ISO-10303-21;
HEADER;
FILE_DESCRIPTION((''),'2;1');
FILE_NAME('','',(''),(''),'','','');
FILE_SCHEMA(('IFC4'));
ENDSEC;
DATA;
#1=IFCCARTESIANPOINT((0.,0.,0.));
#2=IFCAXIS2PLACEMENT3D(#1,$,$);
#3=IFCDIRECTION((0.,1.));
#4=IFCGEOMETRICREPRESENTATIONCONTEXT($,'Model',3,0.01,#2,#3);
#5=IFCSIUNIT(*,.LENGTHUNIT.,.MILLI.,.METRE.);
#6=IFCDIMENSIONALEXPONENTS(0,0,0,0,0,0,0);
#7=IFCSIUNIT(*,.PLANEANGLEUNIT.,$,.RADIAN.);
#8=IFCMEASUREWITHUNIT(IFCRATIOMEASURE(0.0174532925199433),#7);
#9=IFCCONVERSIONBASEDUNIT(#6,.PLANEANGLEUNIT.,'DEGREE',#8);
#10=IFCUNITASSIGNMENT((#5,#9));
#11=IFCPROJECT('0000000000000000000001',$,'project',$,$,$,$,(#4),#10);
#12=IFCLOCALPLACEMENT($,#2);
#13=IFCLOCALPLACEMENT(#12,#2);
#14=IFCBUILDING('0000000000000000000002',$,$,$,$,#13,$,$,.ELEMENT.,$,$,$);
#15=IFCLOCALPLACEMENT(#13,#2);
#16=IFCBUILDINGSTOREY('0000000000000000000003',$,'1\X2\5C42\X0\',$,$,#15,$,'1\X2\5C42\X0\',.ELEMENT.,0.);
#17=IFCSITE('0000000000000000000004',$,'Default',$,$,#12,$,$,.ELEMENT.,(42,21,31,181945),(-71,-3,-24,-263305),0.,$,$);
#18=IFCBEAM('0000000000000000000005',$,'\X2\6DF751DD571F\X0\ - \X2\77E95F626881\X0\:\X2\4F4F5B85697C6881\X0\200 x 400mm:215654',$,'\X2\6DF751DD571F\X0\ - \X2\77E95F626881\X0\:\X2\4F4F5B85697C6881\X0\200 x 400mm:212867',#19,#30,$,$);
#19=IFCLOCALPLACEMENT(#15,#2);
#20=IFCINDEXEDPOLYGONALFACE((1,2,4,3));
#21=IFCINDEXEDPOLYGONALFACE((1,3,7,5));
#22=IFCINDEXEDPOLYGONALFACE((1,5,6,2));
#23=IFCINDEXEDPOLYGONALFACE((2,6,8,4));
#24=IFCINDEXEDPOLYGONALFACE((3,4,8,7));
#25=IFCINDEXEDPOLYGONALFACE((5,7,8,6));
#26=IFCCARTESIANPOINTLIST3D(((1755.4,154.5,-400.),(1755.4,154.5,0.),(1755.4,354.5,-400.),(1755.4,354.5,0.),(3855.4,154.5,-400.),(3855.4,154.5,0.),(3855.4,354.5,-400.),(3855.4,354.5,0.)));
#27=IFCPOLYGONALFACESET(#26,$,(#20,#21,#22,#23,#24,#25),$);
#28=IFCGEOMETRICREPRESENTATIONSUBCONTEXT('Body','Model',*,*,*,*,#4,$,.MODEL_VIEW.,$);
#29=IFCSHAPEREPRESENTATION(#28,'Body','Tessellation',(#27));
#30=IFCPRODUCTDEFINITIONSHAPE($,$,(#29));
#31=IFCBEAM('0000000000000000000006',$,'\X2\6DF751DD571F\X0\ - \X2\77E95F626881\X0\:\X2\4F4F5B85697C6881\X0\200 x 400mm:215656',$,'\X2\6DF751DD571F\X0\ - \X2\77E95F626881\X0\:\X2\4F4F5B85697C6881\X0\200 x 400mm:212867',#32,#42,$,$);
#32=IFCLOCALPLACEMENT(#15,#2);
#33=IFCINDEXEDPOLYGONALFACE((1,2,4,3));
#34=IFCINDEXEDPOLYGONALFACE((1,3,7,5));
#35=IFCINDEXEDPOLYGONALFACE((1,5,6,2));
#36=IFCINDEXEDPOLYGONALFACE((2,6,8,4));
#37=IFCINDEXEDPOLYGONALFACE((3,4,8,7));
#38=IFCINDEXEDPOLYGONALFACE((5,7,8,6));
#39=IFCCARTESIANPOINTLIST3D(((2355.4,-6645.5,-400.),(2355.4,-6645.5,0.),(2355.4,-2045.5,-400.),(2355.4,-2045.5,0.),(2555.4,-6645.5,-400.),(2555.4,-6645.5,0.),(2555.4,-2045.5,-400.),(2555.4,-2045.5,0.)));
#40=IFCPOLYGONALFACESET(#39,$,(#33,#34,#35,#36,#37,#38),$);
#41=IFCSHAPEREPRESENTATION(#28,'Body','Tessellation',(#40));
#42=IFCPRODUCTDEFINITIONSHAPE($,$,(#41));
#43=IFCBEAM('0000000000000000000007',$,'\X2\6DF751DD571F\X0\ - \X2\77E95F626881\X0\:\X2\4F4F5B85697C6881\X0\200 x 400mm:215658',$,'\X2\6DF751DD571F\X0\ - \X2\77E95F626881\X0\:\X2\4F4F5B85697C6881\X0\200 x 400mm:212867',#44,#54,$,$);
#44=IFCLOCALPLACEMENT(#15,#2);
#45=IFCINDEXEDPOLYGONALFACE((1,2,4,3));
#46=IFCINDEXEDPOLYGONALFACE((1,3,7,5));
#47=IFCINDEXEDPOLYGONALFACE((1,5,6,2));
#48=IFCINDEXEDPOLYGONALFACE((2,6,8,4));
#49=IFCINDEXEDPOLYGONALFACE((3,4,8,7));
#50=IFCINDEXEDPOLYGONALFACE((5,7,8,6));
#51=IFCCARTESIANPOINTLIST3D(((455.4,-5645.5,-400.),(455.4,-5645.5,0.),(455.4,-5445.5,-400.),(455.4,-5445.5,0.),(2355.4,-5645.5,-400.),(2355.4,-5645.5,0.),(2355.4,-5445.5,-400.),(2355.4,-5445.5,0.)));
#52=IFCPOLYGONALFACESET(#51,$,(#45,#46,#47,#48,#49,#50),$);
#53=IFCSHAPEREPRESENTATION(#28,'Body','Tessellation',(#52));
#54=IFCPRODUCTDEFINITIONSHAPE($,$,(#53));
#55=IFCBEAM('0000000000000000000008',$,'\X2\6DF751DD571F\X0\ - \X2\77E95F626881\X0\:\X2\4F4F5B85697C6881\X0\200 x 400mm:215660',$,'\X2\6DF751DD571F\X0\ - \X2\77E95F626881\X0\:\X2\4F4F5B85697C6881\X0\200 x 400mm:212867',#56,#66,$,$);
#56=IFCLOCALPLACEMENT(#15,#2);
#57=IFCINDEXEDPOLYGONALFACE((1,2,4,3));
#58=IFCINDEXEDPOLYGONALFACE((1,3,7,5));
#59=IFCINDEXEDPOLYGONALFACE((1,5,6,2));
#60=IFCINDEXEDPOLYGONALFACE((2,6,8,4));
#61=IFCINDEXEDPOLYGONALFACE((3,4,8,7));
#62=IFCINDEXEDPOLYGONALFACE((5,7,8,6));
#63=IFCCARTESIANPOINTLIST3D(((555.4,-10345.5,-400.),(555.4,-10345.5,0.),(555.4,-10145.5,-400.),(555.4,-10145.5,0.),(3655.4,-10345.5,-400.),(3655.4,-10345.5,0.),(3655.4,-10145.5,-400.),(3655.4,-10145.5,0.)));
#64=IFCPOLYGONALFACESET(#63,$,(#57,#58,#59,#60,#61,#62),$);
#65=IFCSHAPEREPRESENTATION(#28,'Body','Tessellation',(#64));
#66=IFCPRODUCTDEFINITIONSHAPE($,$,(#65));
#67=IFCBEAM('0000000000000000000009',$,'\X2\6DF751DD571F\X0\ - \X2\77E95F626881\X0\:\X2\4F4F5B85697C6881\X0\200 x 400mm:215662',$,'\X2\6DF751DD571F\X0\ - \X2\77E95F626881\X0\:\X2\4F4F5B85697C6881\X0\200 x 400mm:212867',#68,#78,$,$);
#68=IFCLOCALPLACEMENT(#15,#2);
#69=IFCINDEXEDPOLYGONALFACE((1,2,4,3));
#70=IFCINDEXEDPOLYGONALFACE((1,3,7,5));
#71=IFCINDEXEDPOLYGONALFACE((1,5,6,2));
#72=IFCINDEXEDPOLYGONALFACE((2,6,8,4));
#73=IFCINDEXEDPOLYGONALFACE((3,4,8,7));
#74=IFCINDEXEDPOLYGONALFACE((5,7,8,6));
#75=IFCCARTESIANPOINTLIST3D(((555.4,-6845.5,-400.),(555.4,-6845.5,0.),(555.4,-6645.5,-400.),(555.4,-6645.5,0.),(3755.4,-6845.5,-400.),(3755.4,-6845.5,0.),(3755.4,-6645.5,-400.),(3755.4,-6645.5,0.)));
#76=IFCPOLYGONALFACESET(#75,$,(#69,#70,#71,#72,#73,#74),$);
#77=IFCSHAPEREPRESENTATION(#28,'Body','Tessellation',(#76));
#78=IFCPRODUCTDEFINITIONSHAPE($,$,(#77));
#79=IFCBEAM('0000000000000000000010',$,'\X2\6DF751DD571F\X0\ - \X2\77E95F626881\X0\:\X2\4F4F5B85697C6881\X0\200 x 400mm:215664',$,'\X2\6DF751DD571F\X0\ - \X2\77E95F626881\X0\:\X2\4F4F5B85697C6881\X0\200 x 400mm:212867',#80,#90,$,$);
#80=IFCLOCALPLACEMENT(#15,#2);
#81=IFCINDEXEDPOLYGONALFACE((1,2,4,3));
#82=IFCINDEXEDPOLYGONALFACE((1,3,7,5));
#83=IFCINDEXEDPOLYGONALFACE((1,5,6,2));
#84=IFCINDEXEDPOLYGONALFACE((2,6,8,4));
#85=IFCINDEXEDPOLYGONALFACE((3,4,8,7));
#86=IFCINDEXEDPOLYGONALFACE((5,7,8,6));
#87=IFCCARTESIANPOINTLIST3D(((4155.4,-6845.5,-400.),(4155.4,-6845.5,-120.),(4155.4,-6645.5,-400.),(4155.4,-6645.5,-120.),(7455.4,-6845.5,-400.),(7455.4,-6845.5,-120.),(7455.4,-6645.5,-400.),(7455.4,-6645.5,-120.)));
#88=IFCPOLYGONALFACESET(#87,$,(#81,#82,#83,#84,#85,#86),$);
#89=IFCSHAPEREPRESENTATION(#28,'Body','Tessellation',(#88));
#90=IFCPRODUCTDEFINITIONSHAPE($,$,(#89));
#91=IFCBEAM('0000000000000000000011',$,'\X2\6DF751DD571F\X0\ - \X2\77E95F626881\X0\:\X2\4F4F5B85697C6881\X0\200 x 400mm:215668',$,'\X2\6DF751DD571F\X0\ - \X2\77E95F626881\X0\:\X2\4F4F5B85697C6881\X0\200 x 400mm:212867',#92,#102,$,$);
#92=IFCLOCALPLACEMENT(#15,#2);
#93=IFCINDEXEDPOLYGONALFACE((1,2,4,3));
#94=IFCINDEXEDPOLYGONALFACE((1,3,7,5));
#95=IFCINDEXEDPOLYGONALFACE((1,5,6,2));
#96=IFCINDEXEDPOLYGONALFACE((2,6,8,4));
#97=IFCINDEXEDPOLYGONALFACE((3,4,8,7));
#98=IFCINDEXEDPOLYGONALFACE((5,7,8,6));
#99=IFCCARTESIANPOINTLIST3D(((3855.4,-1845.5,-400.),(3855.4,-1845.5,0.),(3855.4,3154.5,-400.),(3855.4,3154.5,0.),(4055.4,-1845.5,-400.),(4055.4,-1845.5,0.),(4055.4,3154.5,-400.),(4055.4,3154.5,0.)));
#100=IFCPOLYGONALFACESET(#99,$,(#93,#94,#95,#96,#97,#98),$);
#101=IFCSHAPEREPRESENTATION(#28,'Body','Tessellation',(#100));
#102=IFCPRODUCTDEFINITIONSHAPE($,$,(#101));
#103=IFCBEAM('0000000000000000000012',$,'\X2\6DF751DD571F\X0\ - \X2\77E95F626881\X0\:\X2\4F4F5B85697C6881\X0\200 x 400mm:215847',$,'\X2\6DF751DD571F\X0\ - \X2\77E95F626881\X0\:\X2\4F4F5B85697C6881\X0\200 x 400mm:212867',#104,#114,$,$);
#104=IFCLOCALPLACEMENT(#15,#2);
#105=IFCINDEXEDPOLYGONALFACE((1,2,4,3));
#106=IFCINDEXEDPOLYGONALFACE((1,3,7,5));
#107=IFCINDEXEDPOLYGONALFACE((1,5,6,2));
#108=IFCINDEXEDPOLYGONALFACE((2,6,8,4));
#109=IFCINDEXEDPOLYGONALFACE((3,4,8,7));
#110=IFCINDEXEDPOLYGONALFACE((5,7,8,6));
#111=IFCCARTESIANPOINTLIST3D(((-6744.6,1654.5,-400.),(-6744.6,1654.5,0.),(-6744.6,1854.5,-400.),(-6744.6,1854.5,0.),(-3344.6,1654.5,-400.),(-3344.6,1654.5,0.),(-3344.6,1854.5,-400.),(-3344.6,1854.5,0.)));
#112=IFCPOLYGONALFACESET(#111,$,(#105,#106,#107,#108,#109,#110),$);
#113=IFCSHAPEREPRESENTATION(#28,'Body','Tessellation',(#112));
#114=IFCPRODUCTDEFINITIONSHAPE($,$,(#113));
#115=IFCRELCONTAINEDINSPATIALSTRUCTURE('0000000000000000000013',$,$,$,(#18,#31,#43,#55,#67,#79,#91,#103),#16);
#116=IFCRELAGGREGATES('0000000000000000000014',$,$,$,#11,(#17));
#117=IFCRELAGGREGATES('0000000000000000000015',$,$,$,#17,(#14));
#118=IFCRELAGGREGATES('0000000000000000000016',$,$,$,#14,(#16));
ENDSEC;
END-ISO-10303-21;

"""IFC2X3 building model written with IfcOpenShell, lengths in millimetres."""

from ifc_helpers import new_model, entity, si_unit, converted_unit, direction, frame, frame_2d, origin, place, context, subcontext, project, spatial, rectangle, extrude, element, save


model = new_model("IFC2X3")

# Units and contexts
model_context = context("Model", 3, precision=0.01, world=origin(), true_north=direction((0.0, 1.0)))
body_context = subcontext(model_context, "Body", "Model", "MODEL_VIEW")
ifc_project = project(units=[si_unit("LENGTHUNIT", "METRE", prefix="MILLI"), converted_unit("PLANEANGLEUNIT", "DEGREE", entity("IfcRatioMeasure", 0.0174532925199433), si_unit("PLANEANGLEUNIT", "RADIAN"), dimensions=[0, 0, 0, 0, 0, 0, 0])], contexts=[model_context])

# Site, building, storey
site_placement = place(None, origin())
site = spatial("IfcSite", under=ifc_project, at=site_placement, Name="Default", CompositionType="ELEMENT", RefLatitude=(42, 21, 31, 181945), RefLongitude=(-71, -3, -24, -263305), RefElevation=0.0)
building_placement = place(site_placement, origin())
building = spatial("IfcBuilding", under=site, at=building_placement, CompositionType="ELEMENT")
storey_placement = place(building_placement, origin())
storey = spatial("IfcBuildingStorey", under=building, at=storey_placement, Name="1层", LongName="1层", CompositionType="ELEMENT", Elevation=0.0)

# Beams
beam_1_placement = place(storey_placement, frame((3955.4, 254.5, 0.0), z_axis=(0.0, 0.0, 1.0), x_axis=(-1.0, 0.0, 0.0)))
element("IfcBeam", 1, at=beam_1_placement, inside=storey, Name="混凝土 - 矩形梁:住宅楼梁200 x 400mm:215654", ObjectType="混凝土 - 矩形梁:住宅楼梁200 x 400mm:212867", context=body_context, shape_type="SweptSolid", body=[
    extrude(rectangle(XDim=400.0, YDim=200.0, at=frame_2d((0.0, 0.0), x_axis=(1.0, 0.0))), frame((100.0, 0.0, -200.0), z_axis=(1.0, 0.0, 0.0), x_axis=(0.0, 0.0, -1.0)), (0.0, 0.0, 1.0), 2100.0),
])
beam_2_placement = place(storey_placement, frame((2455.4, -1945.5, 0.0), z_axis=(0.0, 0.0, 1.0), x_axis=(0.0, -1.0, 0.0)))
element("IfcBeam", 2, at=beam_2_placement, inside=storey, Name="混凝土 - 矩形梁:住宅楼梁200 x 400mm:215656", ObjectType="混凝土 - 矩形梁:住宅楼梁200 x 400mm:212867", context=body_context, shape_type="SweptSolid", body=[
    extrude(rectangle(XDim=400.0, YDim=200.0, at=frame_2d((0.0, 0.0), x_axis=(1.0, 0.0))), frame((100.0, 0.0, -200.0), z_axis=(1.0, 0.0, 0.0), x_axis=(0.0, 0.0, -1.0)), (0.0, 0.0, 1.0), 4600.0),
])
beam_3_placement = place(storey_placement, frame((2455.4, -5545.5, 0.0), z_axis=(0.0, 0.0, 1.0), x_axis=(-1.0, 0.0, 0.0)))
element("IfcBeam", 3, at=beam_3_placement, inside=storey, Name="混凝土 - 矩形梁:住宅楼梁200 x 400mm:215658", ObjectType="混凝土 - 矩形梁:住宅楼梁200 x 400mm:212867", context=body_context, shape_type="SweptSolid", body=[
    extrude(rectangle(XDim=400.0, YDim=200.0, at=frame_2d((0.0, 0.0), x_axis=(1.0, 0.0))), frame((100.0, 0.0, -200.0), z_axis=(1.0, 0.0, 0.0), x_axis=(0.0, 0.0, -1.0)), (0.0, 0.0, 1.0), 1900.0),
])
beam_4_placement = place(storey_placement, frame((3655.4, -10245.5, 0.0), z_axis=(0.0, 0.0, 1.0), x_axis=(-1.0, 0.0, 0.0)))
element("IfcBeam", 4, at=beam_4_placement, inside=storey, Name="混凝土 - 矩形梁:住宅楼梁200 x 400mm:215660", ObjectType="混凝土 - 矩形梁:住宅楼梁200 x 400mm:212867", context=body_context, shape_type="SweptSolid", body=[
    extrude(rectangle(XDim=400.0, YDim=200.0, at=frame_2d((0.0, 0.0), x_axis=(1.0, 0.0))), frame((0.0, 0.0, -200.0), z_axis=(1.0, 0.0, 0.0), x_axis=(0.0, 0.0, -1.0)), (0.0, 0.0, 1.0), 3100.0),
])
beam_5_placement = place(storey_placement, frame((3955.4, -6745.5, 0.0), z_axis=(0.0, 0.0, 1.0), x_axis=(-1.0, 0.0, 0.0)))
element("IfcBeam", 5, at=beam_5_placement, inside=storey, Name="混凝土 - 矩形梁:住宅楼梁200 x 400mm:215662", ObjectType="混凝土 - 矩形梁:住宅楼梁200 x 400mm:212867", context=body_context, shape_type="SweptSolid", body=[
    extrude(rectangle(XDim=400.0, YDim=200.0, at=frame_2d((0.0, 0.0), x_axis=(1.0, 0.0))), frame((200.0, 0.0, -200.0), z_axis=(1.0, 0.0, 0.0), x_axis=(0.0, 0.0, -1.0)), (0.0, 0.0, 1.0), 3200.0),
])
beam_6_placement = place(storey_placement, frame((3955.4, -6745.5, 0.0)))
element("IfcBeam", 6, at=beam_6_placement, inside=storey, Name="混凝土 - 矩形梁:住宅楼梁200 x 400mm:215664", ObjectType="混凝土 - 矩形梁:住宅楼梁200 x 400mm:212867", context=body_context, shape_type="SweptSolid", body=[
    extrude(rectangle(XDim=280.0, YDim=200.0, at=frame_2d((0.0, 0.0), x_axis=(1.0, 0.0))), frame((200.0, 0.0, -260.0), z_axis=(1.0, 0.0, 0.0), x_axis=(0.0, 0.0, -1.0)), (0.0, 0.0, 1.0), 3300.0),
])
beam_7_placement = place(storey_placement, frame((3955.4, 3254.5, 0.0), z_axis=(0.0, 0.0, 1.0), x_axis=(0.0, -1.0, 0.0)))
element("IfcBeam", 7, at=beam_7_placement, inside=storey, Name="混凝土 - 矩形梁:住宅楼梁200 x 400mm:215668", ObjectType="混凝土 - 矩形梁:住宅楼梁200 x 400mm:212867", context=body_context, shape_type="SweptSolid", body=[
    extrude(rectangle(XDim=400.0, YDim=200.0, at=frame_2d((0.0, 0.0), x_axis=(1.0, 0.0))), frame((100.0, 0.0, -200.0), z_axis=(1.0, 0.0, 0.0), x_axis=(0.0, 0.0, -1.0)), (0.0, 0.0, 1.0), 5000.0),
])
beam_8_placement = place(storey_placement, frame((-6844.6, 1754.5, 0.0)))
element("IfcBeam", 8, at=beam_8_placement, inside=storey, Name="混凝土 - 矩形梁:住宅楼梁200 x 400mm:215847", ObjectType="混凝土 - 矩形梁:住宅楼梁200 x 400mm:212867", context=body_context, shape_type="SweptSolid", body=[
    extrude(rectangle(XDim=400.0, YDim=200.0, at=frame_2d((0.0, 0.0), x_axis=(1.0, 0.0))), frame((100.0, 0.0, -200.0), z_axis=(1.0, 0.0, 0.0), x_axis=(0.0, 0.0, -1.0)), (0.0, 0.0, 1.0), 3400.0),
])

save(model, "model.ifc")
